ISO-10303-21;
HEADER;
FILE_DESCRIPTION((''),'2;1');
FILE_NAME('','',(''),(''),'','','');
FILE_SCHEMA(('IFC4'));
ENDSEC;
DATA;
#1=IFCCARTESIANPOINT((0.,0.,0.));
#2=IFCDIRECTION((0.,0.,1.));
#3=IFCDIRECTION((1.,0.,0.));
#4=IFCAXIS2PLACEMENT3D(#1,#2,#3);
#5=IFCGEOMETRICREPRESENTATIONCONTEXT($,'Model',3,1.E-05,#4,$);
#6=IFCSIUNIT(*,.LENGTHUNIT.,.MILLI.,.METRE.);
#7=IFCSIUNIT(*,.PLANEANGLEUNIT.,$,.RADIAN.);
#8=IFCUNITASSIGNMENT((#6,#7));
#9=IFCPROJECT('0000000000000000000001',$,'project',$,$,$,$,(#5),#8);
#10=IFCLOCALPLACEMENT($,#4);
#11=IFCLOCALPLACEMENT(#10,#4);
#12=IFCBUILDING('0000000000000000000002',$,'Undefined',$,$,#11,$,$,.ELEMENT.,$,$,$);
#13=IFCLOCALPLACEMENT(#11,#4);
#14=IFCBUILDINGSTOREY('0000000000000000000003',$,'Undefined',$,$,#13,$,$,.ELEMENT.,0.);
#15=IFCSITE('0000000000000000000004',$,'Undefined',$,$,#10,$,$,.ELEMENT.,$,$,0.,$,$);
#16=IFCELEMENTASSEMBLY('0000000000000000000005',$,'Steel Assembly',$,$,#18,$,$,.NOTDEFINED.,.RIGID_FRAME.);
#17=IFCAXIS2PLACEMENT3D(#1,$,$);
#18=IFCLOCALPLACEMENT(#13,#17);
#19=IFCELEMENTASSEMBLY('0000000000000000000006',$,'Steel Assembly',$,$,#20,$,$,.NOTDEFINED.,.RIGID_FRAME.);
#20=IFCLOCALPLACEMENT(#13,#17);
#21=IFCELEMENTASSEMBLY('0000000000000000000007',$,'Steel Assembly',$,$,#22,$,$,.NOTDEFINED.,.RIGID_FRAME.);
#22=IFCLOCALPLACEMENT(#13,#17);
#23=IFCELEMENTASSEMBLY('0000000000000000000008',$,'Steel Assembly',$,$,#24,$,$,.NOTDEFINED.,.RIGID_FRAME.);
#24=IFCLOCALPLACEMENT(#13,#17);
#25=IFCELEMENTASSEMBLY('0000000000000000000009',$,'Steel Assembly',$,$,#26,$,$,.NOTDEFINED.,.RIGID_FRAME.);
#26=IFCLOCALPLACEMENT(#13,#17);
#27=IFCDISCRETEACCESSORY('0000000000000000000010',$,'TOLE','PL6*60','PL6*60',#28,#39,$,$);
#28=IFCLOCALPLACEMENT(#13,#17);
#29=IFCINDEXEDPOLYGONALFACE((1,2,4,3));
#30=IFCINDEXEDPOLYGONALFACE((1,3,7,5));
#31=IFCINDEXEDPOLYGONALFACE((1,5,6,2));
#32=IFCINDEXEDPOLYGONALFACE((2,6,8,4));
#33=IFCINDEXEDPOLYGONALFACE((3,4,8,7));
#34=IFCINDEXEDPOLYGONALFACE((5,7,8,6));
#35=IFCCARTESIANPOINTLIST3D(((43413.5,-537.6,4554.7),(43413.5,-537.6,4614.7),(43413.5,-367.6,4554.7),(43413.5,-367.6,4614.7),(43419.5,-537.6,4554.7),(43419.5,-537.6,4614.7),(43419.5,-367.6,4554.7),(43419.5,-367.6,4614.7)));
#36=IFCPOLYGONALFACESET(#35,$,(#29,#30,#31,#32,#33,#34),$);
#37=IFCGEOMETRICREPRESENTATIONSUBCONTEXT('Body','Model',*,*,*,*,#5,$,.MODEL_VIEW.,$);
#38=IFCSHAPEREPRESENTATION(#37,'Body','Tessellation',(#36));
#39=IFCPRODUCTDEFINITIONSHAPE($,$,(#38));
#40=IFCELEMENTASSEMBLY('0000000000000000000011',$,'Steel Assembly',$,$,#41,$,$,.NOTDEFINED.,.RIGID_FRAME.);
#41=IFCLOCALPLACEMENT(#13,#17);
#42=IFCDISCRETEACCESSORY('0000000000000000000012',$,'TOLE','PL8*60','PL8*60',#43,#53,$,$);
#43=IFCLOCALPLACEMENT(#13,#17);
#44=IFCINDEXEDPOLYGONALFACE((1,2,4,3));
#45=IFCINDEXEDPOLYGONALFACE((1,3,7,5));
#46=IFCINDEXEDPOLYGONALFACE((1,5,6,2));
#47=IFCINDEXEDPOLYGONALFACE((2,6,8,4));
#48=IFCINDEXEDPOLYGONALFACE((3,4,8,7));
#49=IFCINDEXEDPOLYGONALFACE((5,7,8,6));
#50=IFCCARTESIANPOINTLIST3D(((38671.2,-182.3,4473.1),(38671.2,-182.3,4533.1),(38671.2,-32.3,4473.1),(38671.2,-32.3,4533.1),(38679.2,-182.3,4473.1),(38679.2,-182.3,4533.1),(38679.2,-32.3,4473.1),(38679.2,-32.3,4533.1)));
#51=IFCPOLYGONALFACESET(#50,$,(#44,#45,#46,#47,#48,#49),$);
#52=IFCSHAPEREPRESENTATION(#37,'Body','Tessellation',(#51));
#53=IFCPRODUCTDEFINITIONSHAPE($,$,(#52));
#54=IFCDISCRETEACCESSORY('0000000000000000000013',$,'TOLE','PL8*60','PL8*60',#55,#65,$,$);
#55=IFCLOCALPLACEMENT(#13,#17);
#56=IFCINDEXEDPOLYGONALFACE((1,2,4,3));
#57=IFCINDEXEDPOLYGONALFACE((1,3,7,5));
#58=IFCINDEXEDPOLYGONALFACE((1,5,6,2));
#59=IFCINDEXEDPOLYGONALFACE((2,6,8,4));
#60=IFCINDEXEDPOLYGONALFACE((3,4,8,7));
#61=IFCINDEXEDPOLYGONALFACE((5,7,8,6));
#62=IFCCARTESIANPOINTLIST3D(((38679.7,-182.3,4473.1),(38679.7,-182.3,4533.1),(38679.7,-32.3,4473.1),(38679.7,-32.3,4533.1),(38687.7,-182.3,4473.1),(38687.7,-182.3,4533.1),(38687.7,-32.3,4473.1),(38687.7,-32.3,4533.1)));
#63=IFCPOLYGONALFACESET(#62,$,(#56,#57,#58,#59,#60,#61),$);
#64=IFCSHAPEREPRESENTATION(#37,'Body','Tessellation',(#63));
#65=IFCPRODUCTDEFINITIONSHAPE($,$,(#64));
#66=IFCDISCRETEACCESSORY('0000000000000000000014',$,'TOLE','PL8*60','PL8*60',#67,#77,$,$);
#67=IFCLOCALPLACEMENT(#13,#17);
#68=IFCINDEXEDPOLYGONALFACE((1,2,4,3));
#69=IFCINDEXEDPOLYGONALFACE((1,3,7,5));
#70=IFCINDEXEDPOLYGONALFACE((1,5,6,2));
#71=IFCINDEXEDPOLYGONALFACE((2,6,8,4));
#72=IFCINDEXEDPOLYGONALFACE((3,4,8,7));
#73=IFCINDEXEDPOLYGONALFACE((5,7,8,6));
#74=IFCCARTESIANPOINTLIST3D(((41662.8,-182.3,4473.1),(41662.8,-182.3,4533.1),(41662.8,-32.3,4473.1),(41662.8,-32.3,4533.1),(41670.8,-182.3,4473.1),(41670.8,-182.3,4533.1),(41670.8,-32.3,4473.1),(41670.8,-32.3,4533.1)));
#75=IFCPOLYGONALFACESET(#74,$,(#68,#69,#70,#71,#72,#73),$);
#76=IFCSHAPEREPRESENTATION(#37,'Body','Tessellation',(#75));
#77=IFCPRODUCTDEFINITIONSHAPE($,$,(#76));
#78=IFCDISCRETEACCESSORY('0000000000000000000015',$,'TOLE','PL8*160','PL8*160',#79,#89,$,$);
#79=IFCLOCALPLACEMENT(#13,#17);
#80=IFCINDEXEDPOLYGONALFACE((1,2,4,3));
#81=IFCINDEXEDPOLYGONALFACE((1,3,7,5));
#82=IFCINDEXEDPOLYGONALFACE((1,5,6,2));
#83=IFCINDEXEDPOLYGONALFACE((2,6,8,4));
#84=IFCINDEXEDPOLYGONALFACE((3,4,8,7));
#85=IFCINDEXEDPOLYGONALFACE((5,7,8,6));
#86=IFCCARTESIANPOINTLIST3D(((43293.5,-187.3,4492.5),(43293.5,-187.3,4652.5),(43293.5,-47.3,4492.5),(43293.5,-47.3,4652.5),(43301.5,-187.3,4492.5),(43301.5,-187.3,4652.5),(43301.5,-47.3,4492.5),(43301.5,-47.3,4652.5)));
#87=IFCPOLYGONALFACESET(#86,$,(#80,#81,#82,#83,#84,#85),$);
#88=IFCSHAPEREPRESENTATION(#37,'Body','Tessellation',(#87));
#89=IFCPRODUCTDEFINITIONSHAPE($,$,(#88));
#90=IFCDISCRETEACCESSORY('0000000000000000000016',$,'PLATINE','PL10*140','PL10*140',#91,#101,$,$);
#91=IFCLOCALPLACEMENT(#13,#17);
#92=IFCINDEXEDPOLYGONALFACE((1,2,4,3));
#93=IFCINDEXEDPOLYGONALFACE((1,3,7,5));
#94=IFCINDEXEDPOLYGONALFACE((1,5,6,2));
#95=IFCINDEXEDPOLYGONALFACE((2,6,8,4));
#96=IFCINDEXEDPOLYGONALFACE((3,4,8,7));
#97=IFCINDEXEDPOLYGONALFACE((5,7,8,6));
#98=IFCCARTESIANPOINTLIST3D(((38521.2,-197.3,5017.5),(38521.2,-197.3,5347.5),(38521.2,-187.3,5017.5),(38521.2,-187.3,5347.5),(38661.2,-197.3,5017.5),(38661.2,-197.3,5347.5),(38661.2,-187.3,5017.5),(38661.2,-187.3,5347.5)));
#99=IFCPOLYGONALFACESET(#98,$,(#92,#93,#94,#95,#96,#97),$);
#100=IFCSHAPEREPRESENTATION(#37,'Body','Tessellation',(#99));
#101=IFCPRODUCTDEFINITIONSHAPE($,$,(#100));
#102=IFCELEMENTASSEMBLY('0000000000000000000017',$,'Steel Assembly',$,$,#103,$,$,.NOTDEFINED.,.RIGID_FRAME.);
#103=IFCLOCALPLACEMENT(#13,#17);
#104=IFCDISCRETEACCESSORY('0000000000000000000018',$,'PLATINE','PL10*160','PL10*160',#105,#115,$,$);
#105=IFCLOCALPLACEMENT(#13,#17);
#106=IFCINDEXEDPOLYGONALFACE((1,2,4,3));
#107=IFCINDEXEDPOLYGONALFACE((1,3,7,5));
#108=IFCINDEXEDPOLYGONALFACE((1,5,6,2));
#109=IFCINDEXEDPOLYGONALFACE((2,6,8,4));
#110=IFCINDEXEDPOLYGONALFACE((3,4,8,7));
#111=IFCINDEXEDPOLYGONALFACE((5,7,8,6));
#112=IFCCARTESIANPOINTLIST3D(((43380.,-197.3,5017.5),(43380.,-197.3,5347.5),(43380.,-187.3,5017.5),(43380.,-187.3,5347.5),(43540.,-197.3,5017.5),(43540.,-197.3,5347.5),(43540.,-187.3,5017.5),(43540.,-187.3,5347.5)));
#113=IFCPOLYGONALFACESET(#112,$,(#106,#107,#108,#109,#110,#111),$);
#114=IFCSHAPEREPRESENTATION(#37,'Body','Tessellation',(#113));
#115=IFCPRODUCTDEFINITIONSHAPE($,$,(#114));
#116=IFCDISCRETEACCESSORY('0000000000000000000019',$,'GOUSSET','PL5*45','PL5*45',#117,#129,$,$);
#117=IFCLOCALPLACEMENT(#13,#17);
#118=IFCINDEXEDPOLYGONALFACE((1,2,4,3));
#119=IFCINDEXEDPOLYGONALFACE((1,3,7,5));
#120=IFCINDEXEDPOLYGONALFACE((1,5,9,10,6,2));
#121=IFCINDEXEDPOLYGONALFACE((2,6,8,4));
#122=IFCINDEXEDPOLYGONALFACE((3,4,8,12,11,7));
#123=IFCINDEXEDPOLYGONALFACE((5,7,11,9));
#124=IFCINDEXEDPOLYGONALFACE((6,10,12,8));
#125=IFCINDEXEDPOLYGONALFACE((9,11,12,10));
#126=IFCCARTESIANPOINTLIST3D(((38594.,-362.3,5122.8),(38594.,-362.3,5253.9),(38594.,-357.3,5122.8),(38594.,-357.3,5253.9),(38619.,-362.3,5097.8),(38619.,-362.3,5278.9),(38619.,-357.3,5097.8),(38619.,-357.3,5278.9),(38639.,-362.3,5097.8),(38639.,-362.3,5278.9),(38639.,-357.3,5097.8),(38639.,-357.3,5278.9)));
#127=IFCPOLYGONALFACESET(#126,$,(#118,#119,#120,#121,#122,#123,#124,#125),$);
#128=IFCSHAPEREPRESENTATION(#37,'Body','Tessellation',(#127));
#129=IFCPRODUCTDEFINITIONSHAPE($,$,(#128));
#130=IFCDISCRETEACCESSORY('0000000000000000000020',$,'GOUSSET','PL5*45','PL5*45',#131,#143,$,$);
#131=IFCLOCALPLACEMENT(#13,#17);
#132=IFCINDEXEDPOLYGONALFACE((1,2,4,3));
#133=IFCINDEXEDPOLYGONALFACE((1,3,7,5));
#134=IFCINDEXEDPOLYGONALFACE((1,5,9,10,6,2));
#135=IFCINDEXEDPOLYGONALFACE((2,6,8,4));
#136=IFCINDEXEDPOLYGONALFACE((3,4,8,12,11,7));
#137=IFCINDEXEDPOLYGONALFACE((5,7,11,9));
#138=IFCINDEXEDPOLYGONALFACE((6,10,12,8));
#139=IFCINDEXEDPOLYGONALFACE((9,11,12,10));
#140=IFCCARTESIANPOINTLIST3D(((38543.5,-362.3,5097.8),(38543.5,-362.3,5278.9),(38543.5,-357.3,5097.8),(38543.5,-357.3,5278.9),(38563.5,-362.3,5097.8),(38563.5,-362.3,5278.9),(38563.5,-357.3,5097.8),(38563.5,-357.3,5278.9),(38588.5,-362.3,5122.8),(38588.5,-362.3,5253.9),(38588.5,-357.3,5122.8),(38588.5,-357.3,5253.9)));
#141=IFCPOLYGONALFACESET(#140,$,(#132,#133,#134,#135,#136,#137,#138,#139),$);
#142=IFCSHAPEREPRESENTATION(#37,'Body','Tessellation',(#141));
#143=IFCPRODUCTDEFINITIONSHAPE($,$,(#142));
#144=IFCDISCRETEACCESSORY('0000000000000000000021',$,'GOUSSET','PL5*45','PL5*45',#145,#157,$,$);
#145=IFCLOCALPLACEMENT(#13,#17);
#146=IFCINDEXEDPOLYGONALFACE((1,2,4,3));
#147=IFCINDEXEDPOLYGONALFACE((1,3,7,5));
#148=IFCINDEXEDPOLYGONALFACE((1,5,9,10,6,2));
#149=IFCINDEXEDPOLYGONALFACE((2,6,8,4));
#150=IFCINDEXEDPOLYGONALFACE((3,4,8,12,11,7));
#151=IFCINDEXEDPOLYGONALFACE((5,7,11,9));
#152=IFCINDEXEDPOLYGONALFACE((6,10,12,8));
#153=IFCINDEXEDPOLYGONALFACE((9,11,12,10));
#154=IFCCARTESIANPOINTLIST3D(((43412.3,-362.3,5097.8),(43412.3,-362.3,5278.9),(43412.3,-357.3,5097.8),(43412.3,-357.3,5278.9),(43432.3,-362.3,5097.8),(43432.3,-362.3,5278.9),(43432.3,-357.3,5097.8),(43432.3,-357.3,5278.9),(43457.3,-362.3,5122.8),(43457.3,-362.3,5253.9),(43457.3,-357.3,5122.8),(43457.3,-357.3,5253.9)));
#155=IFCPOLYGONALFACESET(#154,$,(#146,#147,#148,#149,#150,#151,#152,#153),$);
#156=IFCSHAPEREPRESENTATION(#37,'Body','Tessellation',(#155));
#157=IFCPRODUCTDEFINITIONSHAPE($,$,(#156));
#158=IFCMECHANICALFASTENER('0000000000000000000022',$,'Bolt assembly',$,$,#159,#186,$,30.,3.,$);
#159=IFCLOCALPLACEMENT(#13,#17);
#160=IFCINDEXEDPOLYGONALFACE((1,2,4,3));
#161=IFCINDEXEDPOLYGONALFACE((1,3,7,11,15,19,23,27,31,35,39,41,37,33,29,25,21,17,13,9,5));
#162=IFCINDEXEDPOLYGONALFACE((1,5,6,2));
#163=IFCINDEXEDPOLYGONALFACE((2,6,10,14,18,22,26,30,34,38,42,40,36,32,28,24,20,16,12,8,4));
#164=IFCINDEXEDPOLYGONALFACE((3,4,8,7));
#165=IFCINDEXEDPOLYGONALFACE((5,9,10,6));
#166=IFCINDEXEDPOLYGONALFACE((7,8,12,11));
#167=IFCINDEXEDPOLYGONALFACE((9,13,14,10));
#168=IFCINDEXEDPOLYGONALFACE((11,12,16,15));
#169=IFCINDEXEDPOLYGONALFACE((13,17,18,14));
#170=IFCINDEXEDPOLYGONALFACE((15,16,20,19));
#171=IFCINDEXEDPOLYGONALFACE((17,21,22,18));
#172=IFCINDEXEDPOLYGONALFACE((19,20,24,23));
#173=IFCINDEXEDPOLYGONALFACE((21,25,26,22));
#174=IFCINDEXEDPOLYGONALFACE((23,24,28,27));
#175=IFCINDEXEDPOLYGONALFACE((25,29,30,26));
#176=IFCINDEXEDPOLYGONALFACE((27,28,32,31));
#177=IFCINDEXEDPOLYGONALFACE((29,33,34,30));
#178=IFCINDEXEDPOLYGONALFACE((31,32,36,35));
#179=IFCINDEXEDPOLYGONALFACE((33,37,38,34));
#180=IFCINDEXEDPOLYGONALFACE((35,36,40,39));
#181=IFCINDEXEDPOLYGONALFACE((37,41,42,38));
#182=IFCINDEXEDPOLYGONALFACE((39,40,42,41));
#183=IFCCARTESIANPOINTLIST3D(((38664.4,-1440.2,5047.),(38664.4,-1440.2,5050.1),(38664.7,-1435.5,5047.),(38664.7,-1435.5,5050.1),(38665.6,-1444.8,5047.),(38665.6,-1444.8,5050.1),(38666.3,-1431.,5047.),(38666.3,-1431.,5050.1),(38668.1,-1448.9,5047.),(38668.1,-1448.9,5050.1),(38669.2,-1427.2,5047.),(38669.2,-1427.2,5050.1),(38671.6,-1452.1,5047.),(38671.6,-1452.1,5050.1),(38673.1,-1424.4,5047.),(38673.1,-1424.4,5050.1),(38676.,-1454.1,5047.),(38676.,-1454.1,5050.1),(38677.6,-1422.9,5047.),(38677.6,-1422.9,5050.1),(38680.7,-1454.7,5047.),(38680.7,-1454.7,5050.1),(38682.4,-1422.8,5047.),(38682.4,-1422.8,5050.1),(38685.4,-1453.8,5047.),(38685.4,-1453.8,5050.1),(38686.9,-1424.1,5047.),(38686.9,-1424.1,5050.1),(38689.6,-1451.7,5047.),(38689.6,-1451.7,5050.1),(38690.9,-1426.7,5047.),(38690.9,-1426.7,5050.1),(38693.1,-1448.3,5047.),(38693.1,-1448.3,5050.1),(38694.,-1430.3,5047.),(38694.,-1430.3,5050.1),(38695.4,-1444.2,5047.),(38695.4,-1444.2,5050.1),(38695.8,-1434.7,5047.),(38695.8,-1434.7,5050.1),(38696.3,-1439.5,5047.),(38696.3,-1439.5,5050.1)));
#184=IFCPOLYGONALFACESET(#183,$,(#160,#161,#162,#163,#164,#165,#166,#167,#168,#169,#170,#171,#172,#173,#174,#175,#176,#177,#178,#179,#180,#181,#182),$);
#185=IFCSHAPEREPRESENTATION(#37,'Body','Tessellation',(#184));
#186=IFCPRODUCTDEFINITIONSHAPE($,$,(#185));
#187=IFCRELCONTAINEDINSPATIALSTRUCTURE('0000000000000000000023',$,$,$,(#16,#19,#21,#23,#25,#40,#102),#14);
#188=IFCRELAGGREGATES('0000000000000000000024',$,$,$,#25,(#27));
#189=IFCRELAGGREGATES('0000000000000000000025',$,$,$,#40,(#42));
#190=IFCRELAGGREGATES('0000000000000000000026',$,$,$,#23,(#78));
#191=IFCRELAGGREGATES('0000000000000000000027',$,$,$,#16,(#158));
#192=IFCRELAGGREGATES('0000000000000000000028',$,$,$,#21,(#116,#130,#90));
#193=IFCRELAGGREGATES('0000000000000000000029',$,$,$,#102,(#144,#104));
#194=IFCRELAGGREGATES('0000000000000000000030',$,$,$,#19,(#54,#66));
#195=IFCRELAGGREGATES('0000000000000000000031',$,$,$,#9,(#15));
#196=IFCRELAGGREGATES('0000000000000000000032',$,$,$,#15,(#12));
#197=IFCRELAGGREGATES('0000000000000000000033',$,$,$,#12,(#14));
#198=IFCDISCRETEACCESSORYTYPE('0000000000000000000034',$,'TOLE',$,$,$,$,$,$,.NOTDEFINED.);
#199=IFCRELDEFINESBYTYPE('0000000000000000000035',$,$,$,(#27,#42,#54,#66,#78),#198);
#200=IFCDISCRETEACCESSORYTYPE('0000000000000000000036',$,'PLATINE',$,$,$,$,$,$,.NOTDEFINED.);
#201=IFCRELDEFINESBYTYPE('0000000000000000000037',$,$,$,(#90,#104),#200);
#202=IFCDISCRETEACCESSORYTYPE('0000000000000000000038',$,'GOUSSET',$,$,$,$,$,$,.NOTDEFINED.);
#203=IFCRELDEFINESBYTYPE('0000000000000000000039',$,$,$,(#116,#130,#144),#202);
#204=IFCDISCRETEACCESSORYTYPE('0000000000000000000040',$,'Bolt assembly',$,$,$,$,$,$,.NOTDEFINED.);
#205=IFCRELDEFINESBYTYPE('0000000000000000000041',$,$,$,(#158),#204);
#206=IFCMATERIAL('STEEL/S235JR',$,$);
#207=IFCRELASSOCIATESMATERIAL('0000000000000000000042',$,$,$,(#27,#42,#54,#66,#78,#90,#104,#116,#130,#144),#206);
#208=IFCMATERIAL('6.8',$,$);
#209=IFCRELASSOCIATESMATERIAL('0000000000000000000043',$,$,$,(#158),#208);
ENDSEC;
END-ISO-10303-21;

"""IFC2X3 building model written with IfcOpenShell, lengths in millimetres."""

from ifc_helpers import new_model, si_unit, frame, origin_with_axes, origin_2d_with_axis, place, context, subcontext, project, spatial, polyline, circle, outline, extrude, source, transform, mapped, material, type_object, element, aggregate, save


model = new_model("IFC2X3")

# Units and contexts
model_context = context("Model", 3, precision=1e-05, world=origin_with_axes())
body_context = subcontext(model_context, "Body", "Model", "MODEL_VIEW")
ifc_project = project(units=[si_unit("LENGTHUNIT", "METRE", prefix="MILLI"), si_unit("PLANEANGLEUNIT", "RADIAN")], contexts=[model_context])

# Site, building, storey
site_placement = place(None, origin_with_axes())
site = spatial("IfcSite", under=ifc_project, at=site_placement, Name="Undefined", CompositionType="ELEMENT", RefElevation=0.0)
building_placement = place(site_placement, origin_with_axes())
building = spatial("IfcBuilding", under=site, at=building_placement, Name="Undefined", CompositionType="ELEMENT")
storey_placement = place(building_placement, origin_with_axes())
storey = spatial("IfcBuildingStorey", under=building, at=storey_placement, Name="Undefined", CompositionType="ELEMENT", Elevation=0.0)

# Element assemblies
ifc_material_1 = material(Name="STEEL/S235JR")
assembly_1_placement = place(storey_placement, origin_with_axes())
assembly_1 = element("IfcElementAssembly", 1, at=assembly_1_placement, inside=storey, Name="Steel Assembly", AssemblyPlace="NOTDEFINED", PredefinedType="RIGID_FRAME")
assembly_2_placement = place(storey_placement, origin_with_axes())
assembly_2 = element("IfcElementAssembly", 2, at=assembly_2_placement, inside=storey, Name="Steel Assembly", AssemblyPlace="NOTDEFINED", PredefinedType="RIGID_FRAME")
assembly_3_placement = place(storey_placement, origin_with_axes())
assembly_3 = element("IfcElementAssembly", 3, at=assembly_3_placement, inside=storey, Name="Steel Assembly", AssemblyPlace="NOTDEFINED", PredefinedType="RIGID_FRAME")
assembly_4_placement = place(storey_placement, origin_with_axes())
assembly_4 = element("IfcElementAssembly", 4, at=assembly_4_placement, inside=storey, Name="Steel Assembly", AssemblyPlace="NOTDEFINED", PredefinedType="RIGID_FRAME")

# Shared definitions
discrete_accessory_type_1 = type_object("IfcDiscreteAccessoryType", Name="TOLE")

# Element assemblies, discrete accessories
assembly_5_placement = place(storey_placement, origin_with_axes())
assembly_5 = element("IfcElementAssembly", 5, at=assembly_5_placement, inside=storey, Name="Steel Assembly", AssemblyPlace="NOTDEFINED", PredefinedType="RIGID_FRAME")
discrete_accessory_1_placement = place(assembly_5_placement, frame((43416.5, -537.6, 4584.7), z_axis=(-1.0, 0.0, 0.0), x_axis=(0.0, 1.0, 0.0)))
discrete_accessory_1 = element("IfcDiscreteAccessory", 6, at=discrete_accessory_1_placement, type_object=discrete_accessory_type_1, material=ifc_material_1, Name="TOLE", Description="PL6*60", ObjectType="PL6*60", context=body_context, shape_type="SweptSolid", body=[
    extrude(outline(polyline([(170.0, 30.0), (170.0, -30.0), (0.0, -30.0), (0.0, 30.0), (170.0, 30.0)])), frame((0.0, 0.0, -3.0), z_axis=(0.0, 0.0, 1.0), x_axis=(1.0, 0.0, 0.0)), (0.0, 0.0, 1.0), 6.0),
])
aggregate(assembly_5, [discrete_accessory_1])
assembly_6_placement = place(storey_placement, origin_with_axes())
assembly_6 = element("IfcElementAssembly", 7, at=assembly_6_placement, inside=storey, Name="Steel Assembly", AssemblyPlace="NOTDEFINED", PredefinedType="RIGID_FRAME")
discrete_accessory_2_placement = place(assembly_6_placement, frame((38675.2, -32.3, 4503.1), z_axis=(1.0, 0.0, 0.0), x_axis=(0.0, -1.0, 0.0)))
discrete_accessory_2 = element("IfcDiscreteAccessory", 8, at=discrete_accessory_2_placement, type_object=discrete_accessory_type_1, material=ifc_material_1, Name="TOLE", Description="PL8*60", ObjectType="PL8*60", context=body_context, shape_type="SweptSolid", body=[
    extrude(outline(polyline([(150.0, -30.0), (0.0, -30.0), (0.0, 30.0), (150.0, 30.0), (150.0, -30.0)])), frame((0.0, 0.0, -4.0), z_axis=(0.0, 0.0, 1.0), x_axis=(1.0, 0.0, 0.0)), (0.0, 0.0, 1.0), 8.0),
])
aggregate(assembly_6, [discrete_accessory_2])

# Discrete accessories
discrete_accessory_3_placement = place(assembly_2_placement, frame((38683.7, -32.3, 4503.1), z_axis=(1.0, 0.0, 0.0), x_axis=(0.0, -1.0, 0.0)))
discrete_accessory_3 = element("IfcDiscreteAccessory", 9, at=discrete_accessory_3_placement, type_object=discrete_accessory_type_1, material=ifc_material_1, Name="TOLE", Description="PL8*60", ObjectType="PL8*60", context=body_context, shape_type="SweptSolid", body=[
    extrude(outline(polyline([(150.0, -30.0), (0.0, -30.0), (0.0, 30.0), (150.0, 30.0), (150.0, -30.0)])), frame((0.0, 0.0, -4.0), z_axis=(0.0, 0.0, 1.0), x_axis=(1.0, 0.0, 0.0)), (0.0, 0.0, 1.0), 8.0),
])
discrete_accessory_4_placement = place(assembly_2_placement, frame((41666.8, -32.3, 4503.1), z_axis=(-1.0, 0.0, 0.0), x_axis=(0.0, -1.0, 0.0)))
discrete_accessory_4 = element("IfcDiscreteAccessory", 10, at=discrete_accessory_4_placement, type_object=discrete_accessory_type_1, material=ifc_material_1, Name="TOLE", Description="PL8*60", ObjectType="PL8*60", context=body_context, shape_type="SweptSolid", body=[
    extrude(outline(polyline([(0.0, -30.0), (0.0, 30.0), (150.0, 30.0), (150.0, -30.0), (0.0, -30.0)])), frame((0.0, 0.0, -4.0), z_axis=(0.0, 0.0, 1.0), x_axis=(1.0, 0.0, 0.0)), (0.0, 0.0, 1.0), 8.0),
])
discrete_accessory_5_placement = place(assembly_4_placement, frame((43297.5, -187.3, 4572.5), z_axis=(1.0, 0.0, 0.0), x_axis=(0.0, 1.0, 0.0)))
discrete_accessory_5 = element("IfcDiscreteAccessory", 11, at=discrete_accessory_5_placement, type_object=discrete_accessory_type_1, material=ifc_material_1, Name="TOLE", Description="PL8*160", ObjectType="PL8*160", context=body_context, shape_type="SweptSolid", body=[
    extrude(outline(polyline([(0.0, 80.0), (140.0, 80.0), (140.0, -80.0), (0.0, -80.0), (0.0, 80.0)])), frame((0.0, 0.0, -4.0), z_axis=(0.0, 0.0, 1.0), x_axis=(1.0, 0.0, 0.0)), (0.0, 0.0, 1.0), 8.0),
])
aggregate(assembly_4, [discrete_accessory_5])
discrete_accessory_type_2 = type_object("IfcDiscreteAccessoryType", Name="PLATINE")
discrete_accessory_6_placement = place(assembly_3_placement, frame((38591.2, -192.3, 5017.5), z_axis=(0.0, -1.0, 0.0), x_axis=(0.0, 0.0, 1.0)))
discrete_accessory_6 = element("IfcDiscreteAccessory", 12, at=discrete_accessory_6_placement, type_object=discrete_accessory_type_2, material=ifc_material_1, Name="PLATINE", Description="PL10*140", ObjectType="PL10*140", context=body_context, shape_type="SweptSolid", body=[
    extrude(outline(polyline([(330.0, 70.0), (330.0, -70.0), (0.0, -70.0), (0.0, 70.0), (330.0, 70.0)])), frame((0.0, 0.0, -5.0), z_axis=(0.0, 0.0, 1.0), x_axis=(1.0, 0.0, 0.0)), (0.0, 0.0, 1.0), 10.0),
])

# Element assembly, discrete accessory
assembly_7_placement = place(storey_placement, origin_with_axes())
assembly_7 = element("IfcElementAssembly", 13, at=assembly_7_placement, inside=storey, Name="Steel Assembly", AssemblyPlace="NOTDEFINED", PredefinedType="RIGID_FRAME")
discrete_accessory_7_placement = place(assembly_7_placement, frame((43460.0, -192.3, 5017.5), z_axis=(0.0, -1.0, 0.0), x_axis=(0.0, 0.0, 1.0)))
discrete_accessory_7 = element("IfcDiscreteAccessory", 14, at=discrete_accessory_7_placement, type_object=discrete_accessory_type_2, material=ifc_material_1, Name="PLATINE", Description="PL10*160", ObjectType="PL10*160", context=body_context, shape_type="SweptSolid", body=[
    extrude(outline(polyline([(330.0, 80.0), (330.0, -80.0), (0.0, -80.0), (0.0, 80.0), (330.0, 80.0)])), frame((0.0, 0.0, -5.0), z_axis=(0.0, 0.0, 1.0), x_axis=(1.0, 0.0, 0.0)), (0.0, 0.0, 1.0), 10.0),
])

# Discrete accessories
discrete_accessory_type_3 = type_object("IfcDiscreteAccessoryType", Name="GOUSSET")
discrete_accessory_8_placement = place(assembly_3_placement, frame((38594.0, -359.8, 5278.9), z_axis=(0.0, 1.0, 0.0), x_axis=(1.0, 0.0, 0.0)))
discrete_accessory_8 = element("IfcDiscreteAccessory", 15, at=discrete_accessory_8_placement, type_object=discrete_accessory_type_3, material=ifc_material_1, Name="GOUSSET", Description="PL5*45", ObjectType="PL5*45", context=body_context, shape_type="SweptSolid", body=[
    extrude(outline(polyline([(0.0, 25.0), (25.0, 0.0), (45.0, 0.0), (45.0, 181.1), (25.0, 181.1), (0.0, 156.1), (0.0, 25.0)])), frame((0.0, 0.0, -2.5), z_axis=(0.0, 0.0, 1.0), x_axis=(1.0, 0.0, 0.0)), (0.0, 0.0, 1.0), 5.0),
])
discrete_accessory_9_placement = place(assembly_3_placement, frame((38588.5, -359.8, 5278.9), z_axis=(0.0, -1.0, 0.0), x_axis=(-1.0, 0.0, 0.0)))
discrete_accessory_9 = element("IfcDiscreteAccessory", 16, at=discrete_accessory_9_placement, type_object=discrete_accessory_type_3, material=ifc_material_1, Name="GOUSSET", Description="PL5*45", ObjectType="PL5*45", context=body_context, shape_type="SweptSolid", body=[
    extrude(outline(polyline([(0.0, 25.0), (25.0, 0.0), (45.0, 0.0), (45.0, 181.1), (25.0, 181.1), (0.0, 156.1), (0.0, 25.0)])), frame((0.0, 0.0, -2.5), z_axis=(0.0, 0.0, 1.0), x_axis=(1.0, 0.0, 0.0)), (0.0, 0.0, 1.0), 5.0),
])
discrete_accessory_10_placement = place(assembly_7_placement, frame((43457.3, -359.8, 5278.9), z_axis=(0.0, -1.0, 0.0), x_axis=(-1.0, 0.0, 0.0)))
discrete_accessory_10 = element("IfcDiscreteAccessory", 17, at=discrete_accessory_10_placement, type_object=discrete_accessory_type_3, material=ifc_material_1, Name="GOUSSET", Description="PL5*45", ObjectType="PL5*45", context=body_context, shape_type="SweptSolid", body=[
    extrude(outline(polyline([(0.0, 25.0), (25.0, 0.0), (45.0, 0.0), (45.0, 181.1), (25.0, 181.1), (0.0, 156.1), (0.0, 25.0)])), frame((0.0, 0.0, -2.5), z_axis=(0.0, 0.0, 1.0), x_axis=(1.0, 0.0, 0.0)), (0.0, 0.0, 1.0), 5.0),
])

# Mechanical fastener
ifc_material_2 = material(Name="6.8")
discrete_accessory_type_4 = type_object("IfcDiscreteAccessoryType", Name="Bolt assembly")
shared_shape_1 = source(origin_with_axes(), body_context, "Body", "SweptSolid", [
    extrude(circle(Radius=16.0, at=origin_2d_with_axis()), frame((0.0, -0.1, 0.0), z_axis=(0.0, 1.0, 0.0), x_axis=(1.0, 0.0, 0.0)), (0.0, 0.0, 1.0), 3.1),
])
mechanical_fastener_1_placement = place(assembly_1_placement, frame((38680.3, -1438.7, 5050.0), z_axis=(0.999741, 0.022754, 0.0), x_axis=(0.022754, -0.999741, 0.000001)))
mechanical_fastener_1 = element("IfcMechanicalFastener", 18, at=mechanical_fastener_1_placement, type_object=discrete_accessory_type_4, material=ifc_material_2, Name="Bolt assembly", NominalDiameter=30.0, NominalLength=3.0, context=body_context, shape_type="MappedRepresentation", body=[
    mapped(shared_shape_1, transform((0.0, 0.0, 0.0))),
])
aggregate(assembly_1, [mechanical_fastener_1])

aggregate(assembly_3, [discrete_accessory_8, discrete_accessory_9, discrete_accessory_6])

aggregate(assembly_7, [discrete_accessory_10, discrete_accessory_7])
aggregate(assembly_2, [discrete_accessory_3, discrete_accessory_4])

save(model, "model.ifc")
